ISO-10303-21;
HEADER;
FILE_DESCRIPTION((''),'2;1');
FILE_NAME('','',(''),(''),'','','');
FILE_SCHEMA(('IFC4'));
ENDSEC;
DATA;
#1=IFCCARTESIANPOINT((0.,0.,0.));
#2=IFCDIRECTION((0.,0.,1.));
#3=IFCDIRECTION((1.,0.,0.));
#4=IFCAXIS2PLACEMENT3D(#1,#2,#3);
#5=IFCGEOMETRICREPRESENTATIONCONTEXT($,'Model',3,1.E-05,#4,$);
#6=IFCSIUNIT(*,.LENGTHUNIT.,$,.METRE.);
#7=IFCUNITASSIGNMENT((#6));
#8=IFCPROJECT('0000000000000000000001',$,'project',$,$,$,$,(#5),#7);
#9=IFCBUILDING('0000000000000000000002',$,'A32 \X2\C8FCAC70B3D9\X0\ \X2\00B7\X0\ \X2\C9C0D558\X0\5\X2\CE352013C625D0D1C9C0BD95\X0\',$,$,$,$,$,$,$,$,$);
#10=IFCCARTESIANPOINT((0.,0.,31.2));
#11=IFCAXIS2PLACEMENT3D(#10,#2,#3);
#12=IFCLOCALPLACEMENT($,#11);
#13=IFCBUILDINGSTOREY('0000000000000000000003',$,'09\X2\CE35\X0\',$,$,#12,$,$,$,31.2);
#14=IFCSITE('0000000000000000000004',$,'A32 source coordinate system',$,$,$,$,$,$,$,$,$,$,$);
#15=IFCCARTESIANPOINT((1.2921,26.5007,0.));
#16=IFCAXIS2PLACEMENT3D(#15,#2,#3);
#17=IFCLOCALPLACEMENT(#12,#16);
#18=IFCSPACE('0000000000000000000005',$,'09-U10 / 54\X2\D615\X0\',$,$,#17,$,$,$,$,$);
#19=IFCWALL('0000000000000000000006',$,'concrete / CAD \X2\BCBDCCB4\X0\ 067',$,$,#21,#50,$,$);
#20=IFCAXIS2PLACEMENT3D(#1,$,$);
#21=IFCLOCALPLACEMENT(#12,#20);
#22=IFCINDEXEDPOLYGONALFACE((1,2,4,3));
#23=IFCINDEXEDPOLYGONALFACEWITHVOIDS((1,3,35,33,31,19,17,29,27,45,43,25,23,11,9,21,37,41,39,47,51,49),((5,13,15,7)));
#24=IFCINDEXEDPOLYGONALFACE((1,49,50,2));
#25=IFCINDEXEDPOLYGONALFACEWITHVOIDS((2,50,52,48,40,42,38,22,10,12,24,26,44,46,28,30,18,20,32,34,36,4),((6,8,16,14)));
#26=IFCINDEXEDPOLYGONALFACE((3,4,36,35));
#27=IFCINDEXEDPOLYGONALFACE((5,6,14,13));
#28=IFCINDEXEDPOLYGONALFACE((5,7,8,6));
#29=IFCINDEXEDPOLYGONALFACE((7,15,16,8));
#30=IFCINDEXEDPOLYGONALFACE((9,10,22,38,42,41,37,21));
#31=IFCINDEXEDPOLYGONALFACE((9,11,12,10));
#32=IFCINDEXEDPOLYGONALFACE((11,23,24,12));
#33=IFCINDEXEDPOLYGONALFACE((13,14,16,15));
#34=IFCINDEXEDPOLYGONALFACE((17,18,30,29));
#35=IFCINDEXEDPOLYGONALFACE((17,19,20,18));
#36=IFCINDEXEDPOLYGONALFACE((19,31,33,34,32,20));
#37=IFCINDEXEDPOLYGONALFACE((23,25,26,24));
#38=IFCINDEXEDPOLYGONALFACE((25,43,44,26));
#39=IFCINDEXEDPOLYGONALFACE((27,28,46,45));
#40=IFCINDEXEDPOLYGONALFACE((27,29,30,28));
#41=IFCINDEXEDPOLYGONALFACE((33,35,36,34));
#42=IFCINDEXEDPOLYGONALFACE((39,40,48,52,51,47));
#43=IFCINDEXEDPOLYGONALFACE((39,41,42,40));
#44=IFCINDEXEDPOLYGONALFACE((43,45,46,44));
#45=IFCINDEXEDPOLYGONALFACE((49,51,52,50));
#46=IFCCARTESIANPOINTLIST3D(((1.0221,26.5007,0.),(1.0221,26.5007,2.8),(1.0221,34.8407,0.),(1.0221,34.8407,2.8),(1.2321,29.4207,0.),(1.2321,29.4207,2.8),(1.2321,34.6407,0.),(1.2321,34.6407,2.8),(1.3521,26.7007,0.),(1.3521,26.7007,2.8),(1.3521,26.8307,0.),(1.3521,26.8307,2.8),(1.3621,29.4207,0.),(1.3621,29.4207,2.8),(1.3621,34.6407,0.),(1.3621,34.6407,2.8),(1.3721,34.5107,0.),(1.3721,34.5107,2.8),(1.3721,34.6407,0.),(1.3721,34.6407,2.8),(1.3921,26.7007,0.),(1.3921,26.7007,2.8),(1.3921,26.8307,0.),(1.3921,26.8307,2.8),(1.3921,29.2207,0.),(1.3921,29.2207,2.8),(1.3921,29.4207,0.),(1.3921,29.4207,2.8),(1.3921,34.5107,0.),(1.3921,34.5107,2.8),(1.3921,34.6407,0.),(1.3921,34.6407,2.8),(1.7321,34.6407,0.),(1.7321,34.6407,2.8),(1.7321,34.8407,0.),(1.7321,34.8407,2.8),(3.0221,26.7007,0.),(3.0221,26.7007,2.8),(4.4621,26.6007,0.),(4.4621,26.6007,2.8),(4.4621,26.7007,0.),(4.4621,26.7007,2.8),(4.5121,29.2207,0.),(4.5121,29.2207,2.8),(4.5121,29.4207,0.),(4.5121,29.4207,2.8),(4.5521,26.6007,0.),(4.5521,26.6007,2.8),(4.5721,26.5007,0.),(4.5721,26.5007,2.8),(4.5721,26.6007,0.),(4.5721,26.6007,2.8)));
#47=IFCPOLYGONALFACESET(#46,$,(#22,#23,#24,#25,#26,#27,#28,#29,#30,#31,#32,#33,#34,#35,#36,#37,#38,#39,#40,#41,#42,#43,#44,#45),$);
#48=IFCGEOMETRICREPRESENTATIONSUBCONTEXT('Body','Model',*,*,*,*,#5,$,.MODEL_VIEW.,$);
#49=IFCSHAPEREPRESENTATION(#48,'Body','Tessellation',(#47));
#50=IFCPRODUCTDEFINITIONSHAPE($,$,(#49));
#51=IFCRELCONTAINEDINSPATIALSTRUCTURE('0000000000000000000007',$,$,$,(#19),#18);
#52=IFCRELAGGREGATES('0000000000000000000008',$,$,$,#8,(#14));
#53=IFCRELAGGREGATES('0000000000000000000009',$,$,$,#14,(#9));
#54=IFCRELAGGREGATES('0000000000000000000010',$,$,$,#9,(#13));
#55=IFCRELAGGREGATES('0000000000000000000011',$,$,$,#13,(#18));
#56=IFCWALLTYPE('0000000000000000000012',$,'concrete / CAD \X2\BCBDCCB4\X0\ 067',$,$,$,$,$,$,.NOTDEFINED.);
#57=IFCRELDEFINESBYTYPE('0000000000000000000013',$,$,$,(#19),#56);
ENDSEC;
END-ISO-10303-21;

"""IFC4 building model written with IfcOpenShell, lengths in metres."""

from ifc_helpers import new_model, si_unit, frame, origin, origin_with_axes, place, context, subcontext, project, spatial, polyline, outline, extrude, source, transform, mapped, type_object, type_shapes, element, save


model = new_model("IFC4")

# Units and contexts
model_context = context("Model", 3, precision=1e-05, world=origin_with_axes())
body_context = subcontext(model_context, "Body", "Model", "MODEL_VIEW")
ifc_project = project(units=[si_unit("LENGTHUNIT", "METRE")], contexts=[model_context])

# Site, building, storey, space
site = spatial("IfcSite", under=ifc_project, Name="A32 source coordinate system")
building = spatial("IfcBuilding", under=site, Name="A32 주거동 · 지하5층–옥탑지붕")
storey_placement = place(None, frame((0.0, 0.0, 31.2), z_axis=(0.0, 0.0, 1.0), x_axis=(1.0, 0.0, 0.0)))
storey = spatial("IfcBuildingStorey", under=building, at=storey_placement, Name="09층", Elevation=31.2)
space_placement = place(storey_placement, frame((1.2921, 26.5007, 0.0), z_axis=(0.0, 0.0, 1.0), x_axis=(1.0, 0.0, 0.0)))
space = spatial("IfcSpace", under=storey, at=space_placement, Name="09-U10 / 54형")

# Wall
wall_type_1 = type_object("IfcWallType", Name="concrete / CAD 벽체 067", PredefinedType="NOTDEFINED")
shared_shape_1 = source(origin(), body_context, "Body", "SweptSolid", [
    extrude(outline(polyline([(0.1, 0.2), (1.73, 0.2), (3.17, 0.2), (3.17, 0.1), (3.26, 0.1), (3.28, 0.1), (3.28, 0.0), (-0.27, 0.0), (-0.27, 8.34), (0.44, 8.34), (0.44, 8.14), (0.1, 8.14), (0.08, 8.14), (0.08, 8.01), (0.1, 8.01), (0.1, 2.92), (3.22, 2.92), (3.22, 2.72), (0.1, 2.72), (0.1, 0.33), (0.06, 0.33), (0.06, 0.2), (0.1, 0.2)]), holes=[polyline([(-0.06, 8.14), (-0.06, 2.92), (0.07, 2.92), (0.07, 8.14), (-0.06, 8.14)])]), origin(), (0.0, 0.0, 1.0), 2.8),
])
type_shapes(wall_type_1, [shared_shape_1])
wall_1_placement = place(space_placement, origin_with_axes())
element("IfcWall", 1, at=wall_1_placement, inside=space, type_object=wall_type_1, Name="concrete / CAD 벽체 067", context=body_context, shape_type="MappedRepresentation", body=[
    mapped(shared_shape_1, transform((0.0, 0.0, 0.0), scale=1.0)),
])

save(model, "model.ifc")
